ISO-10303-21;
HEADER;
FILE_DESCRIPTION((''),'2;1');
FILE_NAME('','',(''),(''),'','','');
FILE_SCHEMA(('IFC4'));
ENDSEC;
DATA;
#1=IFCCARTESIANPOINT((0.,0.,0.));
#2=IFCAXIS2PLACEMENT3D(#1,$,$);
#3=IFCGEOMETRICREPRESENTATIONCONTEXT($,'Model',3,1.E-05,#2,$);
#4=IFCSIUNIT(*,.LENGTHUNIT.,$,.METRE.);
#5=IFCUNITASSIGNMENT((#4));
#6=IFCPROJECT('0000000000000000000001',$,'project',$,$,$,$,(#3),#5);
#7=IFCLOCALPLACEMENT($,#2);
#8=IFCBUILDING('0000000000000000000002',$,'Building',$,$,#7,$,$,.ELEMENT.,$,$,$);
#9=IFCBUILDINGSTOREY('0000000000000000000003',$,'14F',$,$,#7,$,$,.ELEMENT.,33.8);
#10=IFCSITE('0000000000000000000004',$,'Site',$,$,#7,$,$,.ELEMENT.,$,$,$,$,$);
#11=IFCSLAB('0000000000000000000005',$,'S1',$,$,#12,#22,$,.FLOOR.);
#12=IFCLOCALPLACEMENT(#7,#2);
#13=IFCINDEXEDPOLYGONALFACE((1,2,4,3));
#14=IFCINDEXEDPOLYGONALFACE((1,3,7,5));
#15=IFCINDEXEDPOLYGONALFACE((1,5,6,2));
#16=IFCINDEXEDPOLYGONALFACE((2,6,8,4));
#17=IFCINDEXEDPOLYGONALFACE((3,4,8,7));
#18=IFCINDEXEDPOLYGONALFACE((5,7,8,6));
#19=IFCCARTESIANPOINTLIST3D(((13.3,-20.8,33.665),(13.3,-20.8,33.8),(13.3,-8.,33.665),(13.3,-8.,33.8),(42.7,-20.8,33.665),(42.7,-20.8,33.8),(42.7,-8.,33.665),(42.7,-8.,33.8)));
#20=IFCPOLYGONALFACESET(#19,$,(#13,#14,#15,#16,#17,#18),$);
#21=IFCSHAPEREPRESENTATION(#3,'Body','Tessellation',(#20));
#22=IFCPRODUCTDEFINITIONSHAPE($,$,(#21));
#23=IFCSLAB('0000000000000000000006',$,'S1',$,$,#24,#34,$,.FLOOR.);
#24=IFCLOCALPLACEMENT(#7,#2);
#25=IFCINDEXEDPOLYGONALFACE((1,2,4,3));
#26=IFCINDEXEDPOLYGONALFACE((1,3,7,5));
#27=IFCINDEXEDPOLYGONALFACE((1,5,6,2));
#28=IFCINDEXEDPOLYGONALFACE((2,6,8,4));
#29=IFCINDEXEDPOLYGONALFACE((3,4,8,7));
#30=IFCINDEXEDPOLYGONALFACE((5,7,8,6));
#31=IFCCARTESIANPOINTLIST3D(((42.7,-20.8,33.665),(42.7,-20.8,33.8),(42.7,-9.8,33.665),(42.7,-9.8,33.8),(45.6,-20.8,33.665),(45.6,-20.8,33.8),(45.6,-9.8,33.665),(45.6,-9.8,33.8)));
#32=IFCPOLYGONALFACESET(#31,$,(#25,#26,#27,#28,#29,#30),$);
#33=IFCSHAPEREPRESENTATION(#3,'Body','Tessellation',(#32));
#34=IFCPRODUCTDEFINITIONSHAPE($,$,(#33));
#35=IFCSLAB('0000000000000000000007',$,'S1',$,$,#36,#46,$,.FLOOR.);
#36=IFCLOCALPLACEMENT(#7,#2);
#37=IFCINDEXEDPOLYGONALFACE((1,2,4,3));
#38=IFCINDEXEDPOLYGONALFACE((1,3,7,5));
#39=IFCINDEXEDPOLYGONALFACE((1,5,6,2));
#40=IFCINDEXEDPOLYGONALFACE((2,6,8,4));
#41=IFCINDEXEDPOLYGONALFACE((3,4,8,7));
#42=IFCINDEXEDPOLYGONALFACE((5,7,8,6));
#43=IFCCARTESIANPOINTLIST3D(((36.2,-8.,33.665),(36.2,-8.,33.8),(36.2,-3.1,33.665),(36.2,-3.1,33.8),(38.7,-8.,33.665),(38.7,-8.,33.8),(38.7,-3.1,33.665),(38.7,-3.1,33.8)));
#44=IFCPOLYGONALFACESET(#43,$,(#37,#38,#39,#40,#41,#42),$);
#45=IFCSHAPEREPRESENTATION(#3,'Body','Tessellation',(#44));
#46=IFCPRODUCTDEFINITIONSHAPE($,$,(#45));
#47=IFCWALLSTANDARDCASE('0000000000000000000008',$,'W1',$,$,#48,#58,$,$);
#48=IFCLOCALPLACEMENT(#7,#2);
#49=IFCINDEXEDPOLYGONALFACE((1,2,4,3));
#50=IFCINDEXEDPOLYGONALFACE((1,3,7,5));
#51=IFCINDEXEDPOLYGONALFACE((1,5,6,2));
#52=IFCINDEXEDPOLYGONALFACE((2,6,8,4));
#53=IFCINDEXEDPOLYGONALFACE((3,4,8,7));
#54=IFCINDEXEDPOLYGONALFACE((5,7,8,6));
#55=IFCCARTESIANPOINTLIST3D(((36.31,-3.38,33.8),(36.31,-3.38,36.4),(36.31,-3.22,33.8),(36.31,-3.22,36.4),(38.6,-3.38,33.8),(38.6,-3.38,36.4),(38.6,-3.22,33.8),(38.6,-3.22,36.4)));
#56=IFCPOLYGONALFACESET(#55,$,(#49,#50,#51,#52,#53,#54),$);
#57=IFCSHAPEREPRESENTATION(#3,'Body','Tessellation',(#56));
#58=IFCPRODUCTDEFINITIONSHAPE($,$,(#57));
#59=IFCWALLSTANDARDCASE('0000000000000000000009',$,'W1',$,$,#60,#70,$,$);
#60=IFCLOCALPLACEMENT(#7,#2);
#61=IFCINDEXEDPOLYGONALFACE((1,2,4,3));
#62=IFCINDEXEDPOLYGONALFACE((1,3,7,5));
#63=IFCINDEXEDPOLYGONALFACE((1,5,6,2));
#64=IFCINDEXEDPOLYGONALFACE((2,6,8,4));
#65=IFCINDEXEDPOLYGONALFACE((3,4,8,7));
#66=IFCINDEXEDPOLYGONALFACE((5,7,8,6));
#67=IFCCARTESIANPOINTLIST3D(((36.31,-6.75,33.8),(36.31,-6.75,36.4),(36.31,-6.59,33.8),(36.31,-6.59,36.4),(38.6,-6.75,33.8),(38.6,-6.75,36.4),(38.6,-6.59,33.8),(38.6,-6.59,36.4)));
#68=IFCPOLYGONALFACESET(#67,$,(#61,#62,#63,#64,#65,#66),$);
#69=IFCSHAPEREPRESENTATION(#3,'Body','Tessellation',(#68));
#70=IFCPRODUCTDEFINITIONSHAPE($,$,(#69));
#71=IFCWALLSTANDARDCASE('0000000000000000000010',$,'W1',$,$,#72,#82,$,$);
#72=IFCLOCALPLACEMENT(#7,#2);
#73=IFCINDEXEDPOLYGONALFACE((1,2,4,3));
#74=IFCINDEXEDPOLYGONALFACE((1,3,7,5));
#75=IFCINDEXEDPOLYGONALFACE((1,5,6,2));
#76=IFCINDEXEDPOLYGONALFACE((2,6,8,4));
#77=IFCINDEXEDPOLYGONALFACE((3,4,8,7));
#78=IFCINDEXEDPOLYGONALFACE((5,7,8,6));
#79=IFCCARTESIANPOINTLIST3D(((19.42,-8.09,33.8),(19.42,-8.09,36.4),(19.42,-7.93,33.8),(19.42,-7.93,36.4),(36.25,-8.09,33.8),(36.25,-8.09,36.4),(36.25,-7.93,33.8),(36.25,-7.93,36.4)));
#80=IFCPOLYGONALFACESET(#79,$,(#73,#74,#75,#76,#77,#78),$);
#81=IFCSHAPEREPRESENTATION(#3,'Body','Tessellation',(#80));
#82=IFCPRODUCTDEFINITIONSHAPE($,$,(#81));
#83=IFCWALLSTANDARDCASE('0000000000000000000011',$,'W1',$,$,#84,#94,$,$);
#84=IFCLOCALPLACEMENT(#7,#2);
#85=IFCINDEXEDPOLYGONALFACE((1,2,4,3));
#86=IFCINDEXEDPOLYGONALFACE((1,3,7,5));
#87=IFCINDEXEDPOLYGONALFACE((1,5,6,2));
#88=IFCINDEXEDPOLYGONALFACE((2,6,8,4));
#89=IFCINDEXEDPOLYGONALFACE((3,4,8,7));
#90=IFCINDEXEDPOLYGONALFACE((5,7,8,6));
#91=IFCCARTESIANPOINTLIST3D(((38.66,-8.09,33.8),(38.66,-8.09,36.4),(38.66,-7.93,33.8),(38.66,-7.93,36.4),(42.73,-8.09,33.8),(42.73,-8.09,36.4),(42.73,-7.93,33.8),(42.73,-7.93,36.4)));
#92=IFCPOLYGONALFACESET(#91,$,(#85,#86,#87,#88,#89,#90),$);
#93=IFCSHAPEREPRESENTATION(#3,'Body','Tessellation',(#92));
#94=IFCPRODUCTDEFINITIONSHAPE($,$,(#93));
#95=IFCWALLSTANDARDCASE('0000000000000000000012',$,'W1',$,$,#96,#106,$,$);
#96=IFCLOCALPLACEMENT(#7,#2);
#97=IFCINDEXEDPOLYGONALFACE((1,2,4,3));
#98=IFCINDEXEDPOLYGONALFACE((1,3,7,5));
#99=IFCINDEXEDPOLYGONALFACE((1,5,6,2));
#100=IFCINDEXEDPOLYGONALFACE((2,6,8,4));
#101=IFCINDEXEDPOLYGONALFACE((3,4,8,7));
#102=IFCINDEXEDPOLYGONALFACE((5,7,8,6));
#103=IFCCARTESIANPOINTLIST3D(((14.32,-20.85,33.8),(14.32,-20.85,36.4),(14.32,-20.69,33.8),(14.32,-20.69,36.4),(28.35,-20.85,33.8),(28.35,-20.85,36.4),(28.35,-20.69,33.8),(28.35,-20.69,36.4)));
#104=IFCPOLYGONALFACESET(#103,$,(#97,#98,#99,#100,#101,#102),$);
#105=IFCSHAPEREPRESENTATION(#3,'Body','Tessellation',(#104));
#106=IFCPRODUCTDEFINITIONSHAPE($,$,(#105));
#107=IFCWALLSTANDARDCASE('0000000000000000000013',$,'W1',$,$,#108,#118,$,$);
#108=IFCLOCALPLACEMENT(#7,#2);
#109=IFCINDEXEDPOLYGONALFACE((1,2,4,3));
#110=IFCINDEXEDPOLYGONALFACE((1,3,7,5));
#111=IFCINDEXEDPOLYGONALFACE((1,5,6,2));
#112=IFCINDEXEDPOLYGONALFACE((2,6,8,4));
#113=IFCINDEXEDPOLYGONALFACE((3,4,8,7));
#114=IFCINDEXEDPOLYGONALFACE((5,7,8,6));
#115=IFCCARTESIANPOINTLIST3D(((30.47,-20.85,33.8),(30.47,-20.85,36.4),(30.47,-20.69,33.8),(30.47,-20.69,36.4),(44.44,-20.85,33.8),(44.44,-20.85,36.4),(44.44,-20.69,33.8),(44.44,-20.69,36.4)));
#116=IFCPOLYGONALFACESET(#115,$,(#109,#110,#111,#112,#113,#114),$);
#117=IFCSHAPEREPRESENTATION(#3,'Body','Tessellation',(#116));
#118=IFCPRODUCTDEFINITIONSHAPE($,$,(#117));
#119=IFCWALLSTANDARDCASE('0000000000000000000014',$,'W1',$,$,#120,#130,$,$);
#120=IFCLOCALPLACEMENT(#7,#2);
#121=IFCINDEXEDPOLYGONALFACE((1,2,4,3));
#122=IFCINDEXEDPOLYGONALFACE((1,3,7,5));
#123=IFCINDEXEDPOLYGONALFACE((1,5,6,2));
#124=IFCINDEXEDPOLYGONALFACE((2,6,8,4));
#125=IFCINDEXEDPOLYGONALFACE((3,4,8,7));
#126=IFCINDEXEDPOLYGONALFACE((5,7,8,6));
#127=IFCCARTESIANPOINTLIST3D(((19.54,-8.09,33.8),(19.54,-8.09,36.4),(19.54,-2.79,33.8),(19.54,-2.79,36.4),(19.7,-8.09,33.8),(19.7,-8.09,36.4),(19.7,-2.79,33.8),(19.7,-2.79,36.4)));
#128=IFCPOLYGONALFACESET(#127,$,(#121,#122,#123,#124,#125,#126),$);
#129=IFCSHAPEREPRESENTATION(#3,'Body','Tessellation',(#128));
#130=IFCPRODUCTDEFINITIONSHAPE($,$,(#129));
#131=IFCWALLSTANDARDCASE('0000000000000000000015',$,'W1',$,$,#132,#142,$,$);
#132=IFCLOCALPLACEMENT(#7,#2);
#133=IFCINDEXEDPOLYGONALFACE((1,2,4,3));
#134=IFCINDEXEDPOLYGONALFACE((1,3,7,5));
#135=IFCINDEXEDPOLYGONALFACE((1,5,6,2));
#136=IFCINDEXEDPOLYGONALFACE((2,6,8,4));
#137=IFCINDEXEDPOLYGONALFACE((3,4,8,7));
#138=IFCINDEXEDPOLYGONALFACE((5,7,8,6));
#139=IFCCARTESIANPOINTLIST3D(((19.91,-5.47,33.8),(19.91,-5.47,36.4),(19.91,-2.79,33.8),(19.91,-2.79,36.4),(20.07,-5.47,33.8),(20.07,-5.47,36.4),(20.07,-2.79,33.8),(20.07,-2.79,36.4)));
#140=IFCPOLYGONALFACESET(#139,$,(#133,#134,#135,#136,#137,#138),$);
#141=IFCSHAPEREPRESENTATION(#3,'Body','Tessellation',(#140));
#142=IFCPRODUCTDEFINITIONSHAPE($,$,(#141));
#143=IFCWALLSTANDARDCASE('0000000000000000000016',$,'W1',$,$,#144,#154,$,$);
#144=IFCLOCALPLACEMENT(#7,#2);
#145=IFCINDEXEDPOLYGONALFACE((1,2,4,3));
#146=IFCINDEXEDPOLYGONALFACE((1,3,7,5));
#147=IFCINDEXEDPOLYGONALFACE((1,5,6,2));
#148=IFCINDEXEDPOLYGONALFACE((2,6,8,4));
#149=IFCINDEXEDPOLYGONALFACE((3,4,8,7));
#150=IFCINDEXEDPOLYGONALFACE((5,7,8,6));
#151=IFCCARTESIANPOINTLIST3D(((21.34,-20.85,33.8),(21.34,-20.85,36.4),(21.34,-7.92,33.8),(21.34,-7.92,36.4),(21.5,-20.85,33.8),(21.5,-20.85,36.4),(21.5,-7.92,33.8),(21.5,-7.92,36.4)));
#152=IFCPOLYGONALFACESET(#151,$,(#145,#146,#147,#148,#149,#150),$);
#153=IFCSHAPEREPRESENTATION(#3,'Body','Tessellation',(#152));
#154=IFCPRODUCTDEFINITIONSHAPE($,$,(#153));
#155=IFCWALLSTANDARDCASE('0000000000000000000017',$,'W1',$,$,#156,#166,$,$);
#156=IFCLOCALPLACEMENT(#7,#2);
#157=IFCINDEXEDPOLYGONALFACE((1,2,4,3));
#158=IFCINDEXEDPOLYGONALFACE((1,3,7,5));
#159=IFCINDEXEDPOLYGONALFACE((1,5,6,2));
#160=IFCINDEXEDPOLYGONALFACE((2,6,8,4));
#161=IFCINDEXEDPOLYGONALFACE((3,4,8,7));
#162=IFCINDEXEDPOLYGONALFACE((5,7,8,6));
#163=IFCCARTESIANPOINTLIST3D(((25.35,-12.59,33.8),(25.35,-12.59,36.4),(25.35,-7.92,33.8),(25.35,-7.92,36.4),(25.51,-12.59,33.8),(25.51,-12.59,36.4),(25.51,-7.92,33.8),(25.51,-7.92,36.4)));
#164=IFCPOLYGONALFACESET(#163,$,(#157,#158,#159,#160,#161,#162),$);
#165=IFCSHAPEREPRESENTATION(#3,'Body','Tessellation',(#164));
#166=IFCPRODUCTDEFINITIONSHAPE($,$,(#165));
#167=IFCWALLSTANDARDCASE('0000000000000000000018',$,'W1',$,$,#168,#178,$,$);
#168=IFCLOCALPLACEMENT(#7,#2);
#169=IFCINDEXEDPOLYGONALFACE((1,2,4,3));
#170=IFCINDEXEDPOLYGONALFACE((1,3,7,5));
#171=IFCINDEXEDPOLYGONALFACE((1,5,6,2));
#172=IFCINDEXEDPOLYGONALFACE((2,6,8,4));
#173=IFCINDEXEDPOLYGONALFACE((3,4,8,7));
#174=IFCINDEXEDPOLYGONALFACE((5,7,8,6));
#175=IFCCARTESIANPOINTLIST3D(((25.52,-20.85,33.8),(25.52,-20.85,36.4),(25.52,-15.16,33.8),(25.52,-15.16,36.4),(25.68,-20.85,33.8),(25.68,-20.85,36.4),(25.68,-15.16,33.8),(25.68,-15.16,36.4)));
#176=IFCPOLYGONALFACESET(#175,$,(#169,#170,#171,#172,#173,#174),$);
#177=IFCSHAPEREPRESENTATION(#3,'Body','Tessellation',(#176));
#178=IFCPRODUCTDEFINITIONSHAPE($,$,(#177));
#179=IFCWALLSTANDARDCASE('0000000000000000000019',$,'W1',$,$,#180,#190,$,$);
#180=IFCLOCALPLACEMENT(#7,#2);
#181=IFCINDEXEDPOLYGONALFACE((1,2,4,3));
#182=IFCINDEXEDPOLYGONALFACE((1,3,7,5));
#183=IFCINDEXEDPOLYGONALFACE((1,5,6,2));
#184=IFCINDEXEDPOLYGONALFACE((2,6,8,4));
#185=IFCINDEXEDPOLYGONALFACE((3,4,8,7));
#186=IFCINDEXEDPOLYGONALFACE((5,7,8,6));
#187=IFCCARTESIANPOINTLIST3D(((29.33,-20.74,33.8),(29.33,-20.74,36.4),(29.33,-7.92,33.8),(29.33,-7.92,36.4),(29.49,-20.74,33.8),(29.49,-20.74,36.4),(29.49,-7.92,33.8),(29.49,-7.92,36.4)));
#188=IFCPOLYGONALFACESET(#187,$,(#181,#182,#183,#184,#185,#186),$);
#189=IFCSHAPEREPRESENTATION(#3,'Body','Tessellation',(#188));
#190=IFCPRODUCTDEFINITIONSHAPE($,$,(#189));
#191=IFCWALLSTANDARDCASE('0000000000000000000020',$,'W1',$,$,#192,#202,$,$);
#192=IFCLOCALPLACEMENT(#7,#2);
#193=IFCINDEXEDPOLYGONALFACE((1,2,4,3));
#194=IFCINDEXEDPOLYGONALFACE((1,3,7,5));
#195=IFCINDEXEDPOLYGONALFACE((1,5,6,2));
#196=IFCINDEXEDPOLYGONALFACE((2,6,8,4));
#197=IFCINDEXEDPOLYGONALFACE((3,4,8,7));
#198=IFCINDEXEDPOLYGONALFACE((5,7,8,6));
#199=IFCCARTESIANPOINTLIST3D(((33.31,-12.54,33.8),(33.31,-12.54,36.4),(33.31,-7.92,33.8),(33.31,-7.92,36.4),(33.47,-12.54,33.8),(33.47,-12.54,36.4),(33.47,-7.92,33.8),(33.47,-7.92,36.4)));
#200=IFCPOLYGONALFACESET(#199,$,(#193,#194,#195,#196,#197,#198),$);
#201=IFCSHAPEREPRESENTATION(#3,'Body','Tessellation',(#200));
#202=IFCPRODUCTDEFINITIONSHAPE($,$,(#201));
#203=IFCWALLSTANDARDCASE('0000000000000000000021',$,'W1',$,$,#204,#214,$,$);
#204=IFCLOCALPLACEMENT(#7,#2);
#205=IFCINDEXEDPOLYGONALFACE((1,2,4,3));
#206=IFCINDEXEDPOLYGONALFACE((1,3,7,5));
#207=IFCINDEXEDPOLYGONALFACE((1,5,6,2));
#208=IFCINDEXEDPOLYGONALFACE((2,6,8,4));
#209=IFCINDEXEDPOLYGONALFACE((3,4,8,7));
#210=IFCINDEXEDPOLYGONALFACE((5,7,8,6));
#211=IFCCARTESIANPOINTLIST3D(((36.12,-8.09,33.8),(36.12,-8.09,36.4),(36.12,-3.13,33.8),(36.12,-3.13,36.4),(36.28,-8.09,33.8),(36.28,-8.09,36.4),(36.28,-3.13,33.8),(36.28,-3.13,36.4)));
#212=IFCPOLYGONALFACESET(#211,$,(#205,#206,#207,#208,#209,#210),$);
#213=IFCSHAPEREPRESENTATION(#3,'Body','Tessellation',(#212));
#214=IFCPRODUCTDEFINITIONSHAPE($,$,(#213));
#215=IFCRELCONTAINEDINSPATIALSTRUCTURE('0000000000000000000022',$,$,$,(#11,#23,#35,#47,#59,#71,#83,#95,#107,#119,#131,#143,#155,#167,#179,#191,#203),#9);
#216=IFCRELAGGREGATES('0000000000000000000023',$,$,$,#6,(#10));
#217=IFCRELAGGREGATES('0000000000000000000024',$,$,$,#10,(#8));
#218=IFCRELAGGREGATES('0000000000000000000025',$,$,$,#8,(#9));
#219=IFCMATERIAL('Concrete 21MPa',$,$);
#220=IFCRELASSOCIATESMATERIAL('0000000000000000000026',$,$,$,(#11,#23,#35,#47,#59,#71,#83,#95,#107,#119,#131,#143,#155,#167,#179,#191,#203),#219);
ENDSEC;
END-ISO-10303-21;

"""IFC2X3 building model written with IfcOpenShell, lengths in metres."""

from ifc_helpers import new_model, si_unit, frame, origin, origin_2d, place, context, project, spatial, rectangle, extrude, material, element, save


model = new_model("IFC2X3")

# Units and contexts
model_context = context("Model", 3, precision=1e-05, world=origin())
ifc_project = project(units=[si_unit("LENGTHUNIT", "METRE")], contexts=[model_context])

# Site, building, storey
placement = place(None, origin())
site = spatial("IfcSite", under=ifc_project, at=placement, Name="Site", CompositionType="ELEMENT")
building = spatial("IfcBuilding", under=site, at=placement, Name="Building", CompositionType="ELEMENT")
storey = spatial("IfcBuildingStorey", under=building, at=placement, Name="14F", CompositionType="ELEMENT", Elevation=33.8)

# Slabs
ifc_material_1 = material(Name="Concrete 21MPa")
slab_1_placement = place(None, frame((28.0, -14.4, 33.665)))
element("IfcSlab", 1, at=slab_1_placement, inside=storey, material=ifc_material_1, Name="S1", PredefinedType="FLOOR", context=model_context, shape_type="SweptSolid", body=[
    extrude(rectangle(XDim=29.4, YDim=12.8, at=origin_2d()), origin(), (0.0, 0.0, 1.0), 0.135),
])
slab_2_placement = place(None, frame((44.15, -15.3, 33.665)))
element("IfcSlab", 2, at=slab_2_placement, inside=storey, material=ifc_material_1, Name="S1", PredefinedType="FLOOR", context=model_context, shape_type="SweptSolid", body=[
    extrude(rectangle(XDim=2.9, YDim=11.0, at=origin_2d()), origin(), (0.0, 0.0, 1.0), 0.135),
])
slab_3_placement = place(None, frame((37.45, -5.55, 33.665)))
element("IfcSlab", 3, at=slab_3_placement, inside=storey, material=ifc_material_1, Name="S1", PredefinedType="FLOOR", context=model_context, shape_type="SweptSolid", body=[
    extrude(rectangle(XDim=2.5, YDim=4.9, at=origin_2d()), origin(), (0.0, 0.0, 1.0), 0.135),
])

# Walls
for number, where, name in (
    (4, (37.455, -3.3, 33.8), "W1"),
    (5, (37.455, -6.67, 33.8), "W1"),
):
    element("IfcWallStandardCase", number, at=place(None, frame(where)), inside=storey, material=ifc_material_1, Name=name, context=model_context, shape_type="SweptSolid", body=[
        extrude(rectangle(XDim=2.29, YDim=0.16, at=origin_2d()), origin(), (0.0, 0.0, 1.0), 2.6),
    ])
wall_1_placement = place(None, frame((27.835, -8.01, 33.8)))
element("IfcWallStandardCase", 6, at=wall_1_placement, inside=storey, material=ifc_material_1, Name="W1", context=model_context, shape_type="SweptSolid", body=[
    extrude(rectangle(XDim=16.83, YDim=0.16, at=origin_2d()), origin(), (0.0, 0.0, 1.0), 2.6),
])
wall_2_placement = place(None, frame((40.695, -8.01, 33.8)))
element("IfcWallStandardCase", 7, at=wall_2_placement, inside=storey, material=ifc_material_1, Name="W1", context=model_context, shape_type="SweptSolid", body=[
    extrude(rectangle(XDim=4.07, YDim=0.16, at=origin_2d()), origin(), (0.0, 0.0, 1.0), 2.6),
])
wall_3_placement = place(None, frame((21.335, -20.77, 33.8)))
element("IfcWallStandardCase", 8, at=wall_3_placement, inside=storey, material=ifc_material_1, Name="W1", context=model_context, shape_type="SweptSolid", body=[
    extrude(rectangle(XDim=14.03, YDim=0.16, at=origin_2d()), origin(), (0.0, 0.0, 1.0), 2.6),
])
wall_4_placement = place(None, frame((37.455, -20.77, 33.8)))
element("IfcWallStandardCase", 9, at=wall_4_placement, inside=storey, material=ifc_material_1, Name="W1", context=model_context, shape_type="SweptSolid", body=[
    extrude(rectangle(XDim=13.97, YDim=0.16, at=origin_2d()), origin(), (0.0, 0.0, 1.0), 2.6),
])
wall_5_placement = place(None, frame((19.62, -5.44, 33.8)))
element("IfcWallStandardCase", 10, at=wall_5_placement, inside=storey, material=ifc_material_1, Name="W1", context=model_context, shape_type="SweptSolid", body=[
    extrude(rectangle(XDim=0.16, YDim=5.3, at=origin_2d()), origin(), (0.0, 0.0, 1.0), 2.6),
])
wall_6_placement = place(None, frame((19.99, -4.13, 33.8)))
element("IfcWallStandardCase", 11, at=wall_6_placement, inside=storey, material=ifc_material_1, Name="W1", context=model_context, shape_type="SweptSolid", body=[
    extrude(rectangle(XDim=0.16, YDim=2.68, at=origin_2d()), origin(), (0.0, 0.0, 1.0), 2.6),
])
wall_7_placement = place(None, frame((21.42, -14.385, 33.8)))
element("IfcWallStandardCase", 12, at=wall_7_placement, inside=storey, material=ifc_material_1, Name="W1", context=model_context, shape_type="SweptSolid", body=[
    extrude(rectangle(XDim=0.16, YDim=12.93, at=origin_2d()), origin(), (0.0, 0.0, 1.0), 2.6),
])
wall_8_placement = place(None, frame((25.43, -10.255, 33.8)))
element("IfcWallStandardCase", 13, at=wall_8_placement, inside=storey, material=ifc_material_1, Name="W1", context=model_context, shape_type="SweptSolid", body=[
    extrude(rectangle(XDim=0.16, YDim=4.67, at=origin_2d()), origin(), (0.0, 0.0, 1.0), 2.6),
])
wall_9_placement = place(None, frame((25.6, -18.005, 33.8)))
element("IfcWallStandardCase", 14, at=wall_9_placement, inside=storey, material=ifc_material_1, Name="W1", context=model_context, shape_type="SweptSolid", body=[
    extrude(rectangle(XDim=0.16, YDim=5.69, at=origin_2d()), origin(), (0.0, 0.0, 1.0), 2.6),
])
wall_10_placement = place(None, frame((29.41, -14.33, 33.8)))
element("IfcWallStandardCase", 15, at=wall_10_placement, inside=storey, material=ifc_material_1, Name="W1", context=model_context, shape_type="SweptSolid", body=[
    extrude(rectangle(XDim=0.16, YDim=12.82, at=origin_2d()), origin(), (0.0, 0.0, 1.0), 2.6),
])
wall_11_placement = place(None, frame((33.39, -10.23, 33.8)))
element("IfcWallStandardCase", 16, at=wall_11_placement, inside=storey, material=ifc_material_1, Name="W1", context=model_context, shape_type="SweptSolid", body=[
    extrude(rectangle(XDim=0.16, YDim=4.62, at=origin_2d()), origin(), (0.0, 0.0, 1.0), 2.6),
])
wall_12_placement = place(None, frame((36.2, -5.61, 33.8)))
element("IfcWallStandardCase", 17, at=wall_12_placement, inside=storey, material=ifc_material_1, Name="W1", context=model_context, shape_type="SweptSolid", body=[
    extrude(rectangle(XDim=0.16, YDim=4.96, at=origin_2d()), origin(), (0.0, 0.0, 1.0), 2.6),
])

save(model, "model.ifc")
